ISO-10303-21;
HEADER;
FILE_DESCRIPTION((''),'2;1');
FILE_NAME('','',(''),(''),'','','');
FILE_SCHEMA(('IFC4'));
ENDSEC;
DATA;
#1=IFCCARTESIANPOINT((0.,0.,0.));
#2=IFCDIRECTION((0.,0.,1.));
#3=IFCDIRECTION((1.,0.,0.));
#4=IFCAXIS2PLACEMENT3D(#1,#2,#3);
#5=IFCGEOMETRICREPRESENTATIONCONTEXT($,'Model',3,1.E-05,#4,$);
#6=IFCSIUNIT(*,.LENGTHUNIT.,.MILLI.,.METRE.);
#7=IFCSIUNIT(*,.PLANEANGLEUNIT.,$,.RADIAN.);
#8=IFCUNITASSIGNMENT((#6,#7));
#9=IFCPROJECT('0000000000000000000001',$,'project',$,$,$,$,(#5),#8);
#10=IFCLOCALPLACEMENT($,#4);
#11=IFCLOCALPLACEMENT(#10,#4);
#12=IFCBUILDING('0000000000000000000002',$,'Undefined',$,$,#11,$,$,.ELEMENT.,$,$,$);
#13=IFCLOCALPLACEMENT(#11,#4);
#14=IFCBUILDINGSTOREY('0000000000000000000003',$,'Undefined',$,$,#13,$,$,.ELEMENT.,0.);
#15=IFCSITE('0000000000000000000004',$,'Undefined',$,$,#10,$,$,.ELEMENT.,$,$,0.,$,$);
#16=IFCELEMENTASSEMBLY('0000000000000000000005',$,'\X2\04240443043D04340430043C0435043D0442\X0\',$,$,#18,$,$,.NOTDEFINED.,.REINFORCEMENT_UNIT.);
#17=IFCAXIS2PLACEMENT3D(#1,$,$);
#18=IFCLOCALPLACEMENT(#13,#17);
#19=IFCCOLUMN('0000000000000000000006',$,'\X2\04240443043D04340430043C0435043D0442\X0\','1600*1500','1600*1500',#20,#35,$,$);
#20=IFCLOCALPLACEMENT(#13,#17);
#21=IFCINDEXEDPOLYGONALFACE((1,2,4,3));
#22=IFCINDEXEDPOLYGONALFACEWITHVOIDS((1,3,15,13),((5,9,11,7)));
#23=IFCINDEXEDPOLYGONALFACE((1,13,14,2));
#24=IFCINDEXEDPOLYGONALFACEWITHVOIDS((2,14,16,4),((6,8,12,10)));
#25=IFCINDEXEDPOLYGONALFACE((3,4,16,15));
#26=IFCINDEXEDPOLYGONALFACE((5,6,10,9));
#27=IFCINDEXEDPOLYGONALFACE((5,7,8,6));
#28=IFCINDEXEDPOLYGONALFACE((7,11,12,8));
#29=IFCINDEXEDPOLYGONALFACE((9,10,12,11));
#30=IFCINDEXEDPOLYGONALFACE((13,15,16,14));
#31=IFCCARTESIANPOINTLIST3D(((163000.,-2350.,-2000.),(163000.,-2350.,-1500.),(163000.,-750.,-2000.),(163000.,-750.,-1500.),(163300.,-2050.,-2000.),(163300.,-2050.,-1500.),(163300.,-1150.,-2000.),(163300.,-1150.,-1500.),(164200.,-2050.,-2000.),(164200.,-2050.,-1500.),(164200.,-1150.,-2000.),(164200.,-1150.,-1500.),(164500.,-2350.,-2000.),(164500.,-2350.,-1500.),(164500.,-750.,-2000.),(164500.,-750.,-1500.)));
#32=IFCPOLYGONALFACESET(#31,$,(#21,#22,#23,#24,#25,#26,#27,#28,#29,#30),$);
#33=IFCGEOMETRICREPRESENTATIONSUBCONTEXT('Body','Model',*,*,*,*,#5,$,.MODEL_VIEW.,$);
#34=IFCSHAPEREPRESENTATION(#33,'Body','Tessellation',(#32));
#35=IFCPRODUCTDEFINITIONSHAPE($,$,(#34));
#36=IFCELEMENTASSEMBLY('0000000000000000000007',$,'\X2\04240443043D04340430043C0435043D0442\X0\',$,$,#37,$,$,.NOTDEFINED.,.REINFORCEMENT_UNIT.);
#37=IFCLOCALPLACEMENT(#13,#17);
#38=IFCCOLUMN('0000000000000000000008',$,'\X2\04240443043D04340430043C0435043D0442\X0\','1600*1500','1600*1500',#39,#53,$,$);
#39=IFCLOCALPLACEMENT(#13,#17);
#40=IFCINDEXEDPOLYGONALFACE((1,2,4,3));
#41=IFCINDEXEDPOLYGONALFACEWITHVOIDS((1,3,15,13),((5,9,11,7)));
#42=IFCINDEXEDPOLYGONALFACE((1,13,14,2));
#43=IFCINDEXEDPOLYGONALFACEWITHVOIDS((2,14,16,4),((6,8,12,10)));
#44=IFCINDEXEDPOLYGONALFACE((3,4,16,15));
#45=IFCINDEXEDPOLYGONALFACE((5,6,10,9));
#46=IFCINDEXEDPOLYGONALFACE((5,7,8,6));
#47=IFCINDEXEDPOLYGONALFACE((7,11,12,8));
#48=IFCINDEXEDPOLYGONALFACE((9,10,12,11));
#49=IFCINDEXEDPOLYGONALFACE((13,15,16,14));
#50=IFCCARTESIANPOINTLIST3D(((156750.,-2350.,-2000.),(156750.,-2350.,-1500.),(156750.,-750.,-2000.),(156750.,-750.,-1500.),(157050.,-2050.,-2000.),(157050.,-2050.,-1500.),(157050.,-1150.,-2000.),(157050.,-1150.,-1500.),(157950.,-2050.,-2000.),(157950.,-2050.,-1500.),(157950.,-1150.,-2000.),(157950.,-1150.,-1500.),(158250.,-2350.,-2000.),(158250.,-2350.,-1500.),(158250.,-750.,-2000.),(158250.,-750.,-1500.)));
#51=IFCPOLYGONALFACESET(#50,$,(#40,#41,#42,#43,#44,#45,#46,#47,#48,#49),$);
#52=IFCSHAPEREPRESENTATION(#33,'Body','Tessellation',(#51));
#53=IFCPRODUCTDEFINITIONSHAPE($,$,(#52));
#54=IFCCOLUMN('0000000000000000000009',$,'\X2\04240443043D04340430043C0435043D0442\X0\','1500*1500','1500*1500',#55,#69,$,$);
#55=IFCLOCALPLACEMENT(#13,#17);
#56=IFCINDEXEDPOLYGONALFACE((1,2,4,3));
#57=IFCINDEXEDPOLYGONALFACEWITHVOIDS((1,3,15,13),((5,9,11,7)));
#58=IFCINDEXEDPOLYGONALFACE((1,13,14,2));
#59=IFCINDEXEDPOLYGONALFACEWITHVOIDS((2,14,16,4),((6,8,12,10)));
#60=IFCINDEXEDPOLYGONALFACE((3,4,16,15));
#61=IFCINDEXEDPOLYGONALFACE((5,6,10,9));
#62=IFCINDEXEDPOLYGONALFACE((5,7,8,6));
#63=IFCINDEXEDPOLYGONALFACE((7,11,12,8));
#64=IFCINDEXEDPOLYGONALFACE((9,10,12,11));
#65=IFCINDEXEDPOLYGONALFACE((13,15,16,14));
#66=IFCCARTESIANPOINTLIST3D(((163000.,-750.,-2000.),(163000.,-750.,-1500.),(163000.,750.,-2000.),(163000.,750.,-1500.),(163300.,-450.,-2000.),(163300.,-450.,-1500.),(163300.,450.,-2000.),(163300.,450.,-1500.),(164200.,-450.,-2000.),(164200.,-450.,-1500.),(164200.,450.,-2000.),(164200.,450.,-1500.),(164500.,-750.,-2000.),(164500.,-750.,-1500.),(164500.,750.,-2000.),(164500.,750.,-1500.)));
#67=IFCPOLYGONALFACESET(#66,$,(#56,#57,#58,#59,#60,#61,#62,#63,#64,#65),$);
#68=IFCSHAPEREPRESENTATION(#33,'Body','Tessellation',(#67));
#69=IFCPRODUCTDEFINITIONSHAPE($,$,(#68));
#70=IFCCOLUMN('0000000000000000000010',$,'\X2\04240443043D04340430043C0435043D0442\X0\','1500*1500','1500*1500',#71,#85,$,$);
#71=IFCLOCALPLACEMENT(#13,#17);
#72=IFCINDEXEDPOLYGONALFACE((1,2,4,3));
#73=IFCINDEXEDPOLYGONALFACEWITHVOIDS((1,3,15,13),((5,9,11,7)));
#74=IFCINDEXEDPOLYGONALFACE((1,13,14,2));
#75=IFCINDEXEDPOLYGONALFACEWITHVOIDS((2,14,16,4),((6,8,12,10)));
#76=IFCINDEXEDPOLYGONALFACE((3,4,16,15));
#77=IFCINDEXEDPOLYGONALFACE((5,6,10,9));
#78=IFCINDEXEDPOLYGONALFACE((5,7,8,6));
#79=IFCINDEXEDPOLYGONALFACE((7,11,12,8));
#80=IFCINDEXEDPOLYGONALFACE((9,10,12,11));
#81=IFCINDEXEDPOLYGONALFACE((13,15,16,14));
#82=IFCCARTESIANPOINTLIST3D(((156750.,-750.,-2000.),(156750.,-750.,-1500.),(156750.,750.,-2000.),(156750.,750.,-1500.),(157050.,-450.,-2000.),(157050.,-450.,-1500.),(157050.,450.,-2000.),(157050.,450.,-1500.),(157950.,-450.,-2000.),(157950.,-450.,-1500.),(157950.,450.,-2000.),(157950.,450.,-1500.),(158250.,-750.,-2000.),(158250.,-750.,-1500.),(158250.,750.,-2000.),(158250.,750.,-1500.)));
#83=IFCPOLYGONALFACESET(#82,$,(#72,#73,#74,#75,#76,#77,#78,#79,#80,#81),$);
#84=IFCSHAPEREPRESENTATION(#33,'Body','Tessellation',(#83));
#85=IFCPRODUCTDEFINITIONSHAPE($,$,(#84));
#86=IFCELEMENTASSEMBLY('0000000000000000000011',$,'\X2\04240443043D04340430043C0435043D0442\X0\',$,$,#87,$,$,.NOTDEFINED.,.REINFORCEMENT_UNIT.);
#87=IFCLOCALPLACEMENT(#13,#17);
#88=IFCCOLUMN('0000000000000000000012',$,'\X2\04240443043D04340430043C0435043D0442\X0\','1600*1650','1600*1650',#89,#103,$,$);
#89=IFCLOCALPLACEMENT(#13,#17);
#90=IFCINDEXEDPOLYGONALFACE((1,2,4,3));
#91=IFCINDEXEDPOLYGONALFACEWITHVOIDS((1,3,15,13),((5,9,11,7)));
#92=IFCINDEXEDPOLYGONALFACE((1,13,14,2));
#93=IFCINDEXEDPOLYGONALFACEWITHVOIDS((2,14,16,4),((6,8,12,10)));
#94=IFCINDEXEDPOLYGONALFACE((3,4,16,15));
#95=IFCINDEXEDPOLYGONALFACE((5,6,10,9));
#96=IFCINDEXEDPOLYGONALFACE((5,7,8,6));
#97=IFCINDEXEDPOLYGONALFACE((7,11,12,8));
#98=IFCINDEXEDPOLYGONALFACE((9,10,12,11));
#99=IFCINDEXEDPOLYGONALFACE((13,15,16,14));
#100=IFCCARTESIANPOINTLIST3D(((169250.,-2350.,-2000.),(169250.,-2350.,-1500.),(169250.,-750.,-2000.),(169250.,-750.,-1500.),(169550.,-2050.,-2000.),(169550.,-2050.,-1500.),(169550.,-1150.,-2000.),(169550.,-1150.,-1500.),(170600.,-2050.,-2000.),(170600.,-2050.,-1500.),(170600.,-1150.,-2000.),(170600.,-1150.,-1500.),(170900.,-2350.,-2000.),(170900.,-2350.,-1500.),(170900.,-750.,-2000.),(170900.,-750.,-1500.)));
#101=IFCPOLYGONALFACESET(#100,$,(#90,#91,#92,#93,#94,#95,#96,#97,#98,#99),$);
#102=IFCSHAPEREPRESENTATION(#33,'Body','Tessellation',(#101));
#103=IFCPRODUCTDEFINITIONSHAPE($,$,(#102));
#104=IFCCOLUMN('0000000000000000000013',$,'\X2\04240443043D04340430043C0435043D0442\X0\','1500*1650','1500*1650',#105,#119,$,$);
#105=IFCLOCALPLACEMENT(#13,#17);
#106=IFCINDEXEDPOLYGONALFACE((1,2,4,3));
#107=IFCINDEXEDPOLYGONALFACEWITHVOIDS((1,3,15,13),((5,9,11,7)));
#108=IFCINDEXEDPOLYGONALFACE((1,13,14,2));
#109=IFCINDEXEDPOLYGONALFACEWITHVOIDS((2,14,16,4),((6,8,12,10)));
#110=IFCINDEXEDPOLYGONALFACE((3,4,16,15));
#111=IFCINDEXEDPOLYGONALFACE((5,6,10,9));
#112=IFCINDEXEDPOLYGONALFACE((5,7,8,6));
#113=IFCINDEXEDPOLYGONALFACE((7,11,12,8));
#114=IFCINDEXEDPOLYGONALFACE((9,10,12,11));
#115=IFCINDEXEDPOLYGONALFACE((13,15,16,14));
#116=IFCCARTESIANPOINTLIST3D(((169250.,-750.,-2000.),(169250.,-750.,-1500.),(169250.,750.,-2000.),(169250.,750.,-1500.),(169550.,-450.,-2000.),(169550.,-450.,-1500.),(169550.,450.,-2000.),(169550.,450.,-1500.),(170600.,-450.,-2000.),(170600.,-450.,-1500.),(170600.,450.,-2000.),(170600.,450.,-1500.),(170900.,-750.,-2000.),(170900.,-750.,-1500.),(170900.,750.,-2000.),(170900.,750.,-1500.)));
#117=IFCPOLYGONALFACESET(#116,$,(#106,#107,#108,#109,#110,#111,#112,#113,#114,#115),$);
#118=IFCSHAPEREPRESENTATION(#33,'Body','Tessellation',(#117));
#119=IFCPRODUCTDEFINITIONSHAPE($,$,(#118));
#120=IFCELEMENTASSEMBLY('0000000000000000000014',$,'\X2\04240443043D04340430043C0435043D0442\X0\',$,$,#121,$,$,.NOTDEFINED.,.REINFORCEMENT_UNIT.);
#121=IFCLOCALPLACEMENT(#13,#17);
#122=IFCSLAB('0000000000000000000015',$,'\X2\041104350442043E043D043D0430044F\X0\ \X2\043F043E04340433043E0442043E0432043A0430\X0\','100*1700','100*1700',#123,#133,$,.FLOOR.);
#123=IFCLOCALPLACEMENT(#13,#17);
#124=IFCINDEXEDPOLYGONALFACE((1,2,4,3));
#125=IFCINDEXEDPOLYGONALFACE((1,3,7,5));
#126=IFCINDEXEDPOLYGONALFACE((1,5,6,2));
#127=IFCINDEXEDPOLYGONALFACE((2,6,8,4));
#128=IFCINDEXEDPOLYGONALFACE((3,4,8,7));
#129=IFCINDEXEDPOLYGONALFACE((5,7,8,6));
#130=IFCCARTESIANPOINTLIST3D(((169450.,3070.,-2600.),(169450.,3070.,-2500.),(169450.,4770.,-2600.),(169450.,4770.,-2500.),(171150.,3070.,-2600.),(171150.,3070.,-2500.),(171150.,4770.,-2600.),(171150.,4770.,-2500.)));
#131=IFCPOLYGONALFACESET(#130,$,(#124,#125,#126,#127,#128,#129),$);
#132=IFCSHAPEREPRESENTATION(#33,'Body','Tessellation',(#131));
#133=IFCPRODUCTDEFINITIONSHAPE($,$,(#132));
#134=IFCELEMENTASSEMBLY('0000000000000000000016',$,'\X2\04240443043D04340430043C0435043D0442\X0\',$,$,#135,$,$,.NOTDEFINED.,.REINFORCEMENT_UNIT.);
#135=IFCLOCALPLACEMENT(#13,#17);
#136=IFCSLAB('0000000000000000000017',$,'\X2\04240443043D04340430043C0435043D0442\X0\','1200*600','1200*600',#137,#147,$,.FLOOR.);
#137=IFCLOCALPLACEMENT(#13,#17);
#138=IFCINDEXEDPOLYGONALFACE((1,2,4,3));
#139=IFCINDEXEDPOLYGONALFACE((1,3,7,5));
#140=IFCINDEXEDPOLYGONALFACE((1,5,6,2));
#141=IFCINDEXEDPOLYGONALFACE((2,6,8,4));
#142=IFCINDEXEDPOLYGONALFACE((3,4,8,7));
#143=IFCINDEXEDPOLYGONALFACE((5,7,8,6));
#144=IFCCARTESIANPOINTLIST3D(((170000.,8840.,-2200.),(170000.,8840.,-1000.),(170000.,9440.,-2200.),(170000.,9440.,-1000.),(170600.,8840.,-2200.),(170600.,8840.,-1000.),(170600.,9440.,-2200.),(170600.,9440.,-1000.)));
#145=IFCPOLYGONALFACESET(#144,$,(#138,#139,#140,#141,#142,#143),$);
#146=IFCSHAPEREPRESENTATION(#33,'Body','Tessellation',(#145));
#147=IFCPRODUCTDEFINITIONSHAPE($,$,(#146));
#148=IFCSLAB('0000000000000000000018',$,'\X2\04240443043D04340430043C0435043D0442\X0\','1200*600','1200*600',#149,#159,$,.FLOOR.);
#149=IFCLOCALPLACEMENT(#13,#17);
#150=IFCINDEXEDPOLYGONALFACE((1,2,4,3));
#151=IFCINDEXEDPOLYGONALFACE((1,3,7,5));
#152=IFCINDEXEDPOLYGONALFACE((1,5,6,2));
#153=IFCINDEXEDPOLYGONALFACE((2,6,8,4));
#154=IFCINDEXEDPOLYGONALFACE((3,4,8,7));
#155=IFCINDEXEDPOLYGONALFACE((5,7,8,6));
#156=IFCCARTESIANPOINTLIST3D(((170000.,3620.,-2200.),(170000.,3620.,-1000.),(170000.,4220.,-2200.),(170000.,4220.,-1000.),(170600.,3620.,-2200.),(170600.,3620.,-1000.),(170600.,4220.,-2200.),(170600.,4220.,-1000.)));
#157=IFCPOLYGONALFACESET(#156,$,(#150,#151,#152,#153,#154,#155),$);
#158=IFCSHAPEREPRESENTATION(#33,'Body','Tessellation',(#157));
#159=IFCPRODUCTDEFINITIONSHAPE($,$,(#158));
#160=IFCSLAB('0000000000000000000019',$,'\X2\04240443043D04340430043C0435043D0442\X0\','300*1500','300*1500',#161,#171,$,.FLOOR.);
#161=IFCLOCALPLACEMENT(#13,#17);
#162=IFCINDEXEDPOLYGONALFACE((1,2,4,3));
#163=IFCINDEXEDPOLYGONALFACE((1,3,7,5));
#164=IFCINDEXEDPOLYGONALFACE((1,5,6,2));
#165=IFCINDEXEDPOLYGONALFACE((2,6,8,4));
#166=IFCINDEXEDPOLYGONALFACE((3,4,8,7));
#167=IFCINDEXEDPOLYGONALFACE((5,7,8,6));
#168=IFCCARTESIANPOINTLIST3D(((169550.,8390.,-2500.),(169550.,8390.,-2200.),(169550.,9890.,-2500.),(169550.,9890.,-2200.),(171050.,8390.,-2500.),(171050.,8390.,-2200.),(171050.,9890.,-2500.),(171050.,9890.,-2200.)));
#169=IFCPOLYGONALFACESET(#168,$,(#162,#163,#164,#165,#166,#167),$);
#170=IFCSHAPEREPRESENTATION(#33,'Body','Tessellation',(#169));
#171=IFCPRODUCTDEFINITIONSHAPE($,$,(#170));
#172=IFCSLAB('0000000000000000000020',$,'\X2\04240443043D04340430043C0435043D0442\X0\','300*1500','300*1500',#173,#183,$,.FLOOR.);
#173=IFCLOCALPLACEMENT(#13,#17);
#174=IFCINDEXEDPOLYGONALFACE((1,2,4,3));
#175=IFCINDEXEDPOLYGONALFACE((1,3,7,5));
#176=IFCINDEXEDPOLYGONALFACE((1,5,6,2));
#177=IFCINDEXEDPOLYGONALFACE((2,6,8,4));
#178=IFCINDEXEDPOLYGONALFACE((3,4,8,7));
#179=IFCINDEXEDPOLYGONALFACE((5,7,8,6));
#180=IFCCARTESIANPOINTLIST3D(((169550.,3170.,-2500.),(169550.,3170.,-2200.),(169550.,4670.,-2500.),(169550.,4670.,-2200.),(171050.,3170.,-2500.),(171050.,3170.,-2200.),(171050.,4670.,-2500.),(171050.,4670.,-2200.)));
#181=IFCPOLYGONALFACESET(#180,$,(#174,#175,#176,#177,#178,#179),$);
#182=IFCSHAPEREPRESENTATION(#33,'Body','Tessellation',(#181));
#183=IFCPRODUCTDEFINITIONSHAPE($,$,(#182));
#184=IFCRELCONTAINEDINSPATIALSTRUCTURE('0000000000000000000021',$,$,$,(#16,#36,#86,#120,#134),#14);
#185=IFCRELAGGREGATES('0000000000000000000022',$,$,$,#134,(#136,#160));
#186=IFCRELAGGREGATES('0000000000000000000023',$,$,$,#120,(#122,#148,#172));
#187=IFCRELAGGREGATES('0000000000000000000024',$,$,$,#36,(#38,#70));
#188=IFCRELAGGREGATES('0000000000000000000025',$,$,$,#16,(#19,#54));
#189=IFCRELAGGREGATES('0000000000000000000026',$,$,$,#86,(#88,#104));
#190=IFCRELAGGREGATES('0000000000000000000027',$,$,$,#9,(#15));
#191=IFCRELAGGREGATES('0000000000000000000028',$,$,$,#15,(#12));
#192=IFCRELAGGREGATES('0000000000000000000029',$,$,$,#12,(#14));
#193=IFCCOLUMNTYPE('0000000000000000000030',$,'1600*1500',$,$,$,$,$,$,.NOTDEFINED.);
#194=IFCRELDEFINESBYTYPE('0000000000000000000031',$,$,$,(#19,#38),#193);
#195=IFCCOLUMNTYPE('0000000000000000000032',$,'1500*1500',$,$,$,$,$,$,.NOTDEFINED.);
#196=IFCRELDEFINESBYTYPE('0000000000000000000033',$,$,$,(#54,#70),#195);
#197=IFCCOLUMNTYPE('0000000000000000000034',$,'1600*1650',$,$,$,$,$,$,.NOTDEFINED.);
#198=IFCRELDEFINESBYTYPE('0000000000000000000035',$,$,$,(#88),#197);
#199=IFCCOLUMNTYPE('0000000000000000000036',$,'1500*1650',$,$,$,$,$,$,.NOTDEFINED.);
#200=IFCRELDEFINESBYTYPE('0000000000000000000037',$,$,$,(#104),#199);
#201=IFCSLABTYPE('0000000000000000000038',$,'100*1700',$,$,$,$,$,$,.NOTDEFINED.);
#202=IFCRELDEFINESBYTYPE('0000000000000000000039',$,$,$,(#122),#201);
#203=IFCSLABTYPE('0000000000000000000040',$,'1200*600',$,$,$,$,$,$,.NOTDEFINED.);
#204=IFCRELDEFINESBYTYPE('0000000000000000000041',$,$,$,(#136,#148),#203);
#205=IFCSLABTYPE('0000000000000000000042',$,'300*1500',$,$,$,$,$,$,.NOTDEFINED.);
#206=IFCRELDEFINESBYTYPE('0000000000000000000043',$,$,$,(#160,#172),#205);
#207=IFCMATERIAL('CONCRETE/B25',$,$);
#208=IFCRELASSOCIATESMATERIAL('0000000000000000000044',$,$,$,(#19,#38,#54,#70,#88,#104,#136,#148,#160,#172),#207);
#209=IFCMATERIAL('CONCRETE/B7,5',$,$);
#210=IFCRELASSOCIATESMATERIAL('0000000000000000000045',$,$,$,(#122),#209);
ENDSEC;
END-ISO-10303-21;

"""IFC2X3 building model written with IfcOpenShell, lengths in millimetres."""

from ifc_helpers import new_model, si_unit, frame, origin_with_axes, origin_2d_with_axis, place, context, subcontext, project, spatial, polyline, rectangle, outline, extrude, boolean, material, type_object, element, aggregate, save


model = new_model("IFC2X3")

# Units and contexts
model_context = context("Model", 3, precision=1e-05, world=origin_with_axes())
body_context = subcontext(model_context, "Body", "Model", "MODEL_VIEW")
ifc_project = project(units=[si_unit("LENGTHUNIT", "METRE", prefix="MILLI"), si_unit("PLANEANGLEUNIT", "RADIAN")], contexts=[model_context])

# Site, building, storey
site_placement = place(None, origin_with_axes())
site = spatial("IfcSite", under=ifc_project, at=site_placement, Name="Undefined", CompositionType="ELEMENT", RefElevation=0.0)
building_placement = place(site_placement, origin_with_axes())
building = spatial("IfcBuilding", under=site, at=building_placement, Name="Undefined", CompositionType="ELEMENT")
storey_placement = place(building_placement, origin_with_axes())
storey = spatial("IfcBuildingStorey", under=building, at=storey_placement, Name="Undefined", CompositionType="ELEMENT", Elevation=0.0)

# Element assemblies, columns
assembly_1_placement = place(storey_placement, origin_with_axes())
assembly_1 = element("IfcElementAssembly", 1, at=assembly_1_placement, inside=storey, Name="Фундамент", AssemblyPlace="NOTDEFINED", PredefinedType="REINFORCEMENT_UNIT")
ifc_material_1 = material(Name="CONCRETE/B25")
column_type_1 = type_object("IfcColumnType", Name="1600*1500", PredefinedType="NOTDEFINED")
column_1_placement = place(assembly_1_placement, frame((163750.0, -1550.0, -2000.0), z_axis=(0.0, 0.0, 1.0), x_axis=(0.0, -1.0, 0.0)))
column_1 = element("IfcColumn", 2, at=column_1_placement, type_object=column_type_1, material=ifc_material_1, Name="Фундамент", Description="1600*1500", ObjectType="1600*1500", context=body_context, shape_type="CSG", body=[
    boolean("DIFFERENCE", extrude(rectangle(XDim=1500.0, YDim=1600.0, at=origin_2d_with_axis()), frame((0.0, 0.0, 500.0), z_axis=(0.0, 0.0, -1.0), x_axis=(0.0, 1.0, 0.0)), (0.0, 0.0, 1.0), 500.0), extrude(outline(polyline([(0.0, 0.0), (900.0, 0.0), (900.0, 900.0), (0.0, 900.0), (0.0, 0.0)])), frame((-400.0, -450.0, -100.0), z_axis=(0.0, 0.0, 1.0), x_axis=(1.0, 0.0, 0.0)), (0.0, 0.0, 1.0), 700.0)),
])
assembly_2_placement = place(storey_placement, origin_with_axes())
assembly_2 = element("IfcElementAssembly", 3, at=assembly_2_placement, inside=storey, Name="Фундамент", AssemblyPlace="NOTDEFINED", PredefinedType="REINFORCEMENT_UNIT")
column_2_placement = place(assembly_2_placement, frame((157500.0, -1550.0, -2000.0), z_axis=(0.0, 0.0, 1.0), x_axis=(0.0, -1.0, 0.0)))
column_2 = element("IfcColumn", 4, at=column_2_placement, type_object=column_type_1, material=ifc_material_1, Name="Фундамент", Description="1600*1500", ObjectType="1600*1500", context=body_context, shape_type="CSG", body=[
    boolean("DIFFERENCE", extrude(rectangle(XDim=1500.0, YDim=1600.0, at=origin_2d_with_axis()), frame((0.0, 0.0, 500.0), z_axis=(0.0, 0.0, -1.0), x_axis=(0.0, 1.0, 0.0)), (0.0, 0.0, 1.0), 500.0), extrude(outline(polyline([(0.0, 0.0), (900.0, 0.0), (900.0, 900.0), (0.0, 900.0), (0.0, 0.0)])), frame((-400.0, -450.0, -100.0), z_axis=(0.0, 0.0, 1.0), x_axis=(1.0, 0.0, 0.0)), (0.0, 0.0, 1.0), 700.0)),
])

# Columns
column_type_2 = type_object("IfcColumnType", Name="1500*1500", PredefinedType="NOTDEFINED")
column_3_placement = place(assembly_1_placement, frame((163750.0, 0.0, -2000.0), z_axis=(0.0, 0.0, 1.0), x_axis=(0.0, -1.0, 0.0)))
column_3 = element("IfcColumn", 5, at=column_3_placement, type_object=column_type_2, material=ifc_material_1, Name="Фундамент", Description="1500*1500", ObjectType="1500*1500", context=body_context, shape_type="CSG", body=[
    boolean("DIFFERENCE", extrude(rectangle(XDim=1500.0, YDim=1500.0, at=origin_2d_with_axis()), frame((0.0, 0.0, 500.0), z_axis=(0.0, 0.0, -1.0), x_axis=(0.0, 1.0, 0.0)), (0.0, 0.0, 1.0), 500.0), extrude(outline(polyline([(0.0, 0.0), (900.0, 0.0), (900.0, 900.0), (0.0, 900.0), (0.0, 0.0)])), frame((-450.0, -450.0, -100.0), z_axis=(0.0, 0.0, 1.0), x_axis=(1.0, 0.0, 0.0)), (0.0, 0.0, 1.0), 700.0)),
])
column_4_placement = place(assembly_2_placement, frame((157500.0, 0.0, -2000.0), z_axis=(0.0, 0.0, 1.0), x_axis=(0.0, -1.0, 0.0)))
column_4 = element("IfcColumn", 6, at=column_4_placement, type_object=column_type_2, material=ifc_material_1, Name="Фундамент", Description="1500*1500", ObjectType="1500*1500", context=body_context, shape_type="CSG", body=[
    boolean("DIFFERENCE", extrude(rectangle(XDim=1500.0, YDim=1500.0, at=origin_2d_with_axis()), frame((0.0, 0.0, 500.0), z_axis=(0.0, 0.0, -1.0), x_axis=(0.0, 1.0, 0.0)), (0.0, 0.0, 1.0), 500.0), extrude(outline(polyline([(0.0, 0.0), (900.0, 0.0), (900.0, 900.0), (0.0, 900.0), (0.0, 0.0)])), frame((-450.0, -450.0, -100.0), z_axis=(0.0, 0.0, 1.0), x_axis=(1.0, 0.0, 0.0)), (0.0, 0.0, 1.0), 700.0)),
])

# Element assembly, columns
assembly_3_placement = place(storey_placement, origin_with_axes())
assembly_3 = element("IfcElementAssembly", 7, at=assembly_3_placement, inside=storey, Name="Фундамент", AssemblyPlace="NOTDEFINED", PredefinedType="REINFORCEMENT_UNIT")
column_type_3 = type_object("IfcColumnType", Name="1600*1650", PredefinedType="NOTDEFINED")
column_5_placement = place(assembly_3_placement, frame((170075.0, -1550.0, -2000.0), z_axis=(0.0, 0.0, 1.0), x_axis=(0.0, -1.0, 0.0)))
column_5 = element("IfcColumn", 8, at=column_5_placement, type_object=column_type_3, material=ifc_material_1, Name="Фундамент", Description="1600*1650", ObjectType="1600*1650", context=body_context, shape_type="CSG", body=[
    boolean("DIFFERENCE", extrude(rectangle(XDim=1650.0, YDim=1600.0, at=origin_2d_with_axis()), frame((0.0, 0.0, 500.0), z_axis=(0.0, 0.0, -1.0), x_axis=(0.0, 1.0, 0.0)), (0.0, 0.0, 1.0), 500.0), extrude(outline(polyline([(0.0, 0.0), (900.0, 0.0), (900.0, 1050.0), (0.0, 1050.0), (0.0, 0.0)])), frame((-400.0, -525.0, -100.0), z_axis=(0.0, 0.0, 1.0), x_axis=(1.0, 0.0, 0.0)), (0.0, 0.0, 1.0), 700.0)),
])
column_type_4 = type_object("IfcColumnType", Name="1500*1650", PredefinedType="NOTDEFINED")
column_6_placement = place(assembly_3_placement, frame((170075.0, 0.0, -2000.0), z_axis=(0.0, 0.0, 1.0), x_axis=(0.0, -1.0, 0.0)))
column_6 = element("IfcColumn", 9, at=column_6_placement, type_object=column_type_4, material=ifc_material_1, Name="Фундамент", Description="1500*1650", ObjectType="1500*1650", context=body_context, shape_type="CSG", body=[
    boolean("DIFFERENCE", extrude(rectangle(XDim=1650.0, YDim=1500.0, at=origin_2d_with_axis()), frame((0.0, 0.0, 500.0), z_axis=(0.0, 0.0, -1.0), x_axis=(0.0, 1.0, 0.0)), (0.0, 0.0, 1.0), 500.0), extrude(outline(polyline([(0.0, 0.0), (900.0, 0.0), (900.0, 1050.0), (0.0, 1050.0), (0.0, 0.0)])), frame((-450.0, -525.0, -100.0), z_axis=(0.0, 0.0, 1.0), x_axis=(1.0, 0.0, 0.0)), (0.0, 0.0, 1.0), 700.0)),
])

# Element assemblies, slabs
assembly_4_placement = place(storey_placement, origin_with_axes())
assembly_4 = element("IfcElementAssembly", 10, at=assembly_4_placement, inside=storey, Name="Фундамент", AssemblyPlace="NOTDEFINED", PredefinedType="REINFORCEMENT_UNIT")
ifc_material_2 = material(Name="CONCRETE/B7,5")
slab_type_1 = type_object("IfcSlabType", Name="100*1700", PredefinedType="NOTDEFINED")
slab_1_placement = place(assembly_4_placement, frame((169450.0, 4770.0, -2550.0), z_axis=(0.0, 0.0, 1.0), x_axis=(0.0, -1.0, 0.0)))
slab_1 = element("IfcSlab", 11, at=slab_1_placement, type_object=slab_type_1, material=ifc_material_2, Name="Бетонная подготовка", Description="100*1700", ObjectType="100*1700", PredefinedType="FLOOR", context=body_context, shape_type="SweptSolid", body=[
    extrude(outline(polyline([(0.0, 0.0), (1700.0, 0.0), (1700.0, 1700.0), (0.0, 1700.0), (0.0, 0.0)])), frame((0.0, 0.0, -50.0), z_axis=(0.0, 0.0, 1.0), x_axis=(1.0, 0.0, 0.0)), (0.0, 0.0, 1.0), 100.0),
])
assembly_5_placement = place(storey_placement, origin_with_axes())
assembly_5 = element("IfcElementAssembly", 12, at=assembly_5_placement, inside=storey, Name="Фундамент", AssemblyPlace="NOTDEFINED", PredefinedType="REINFORCEMENT_UNIT")
slab_type_2 = type_object("IfcSlabType", Name="1200*600", PredefinedType="NOTDEFINED")
slab_2_placement = place(assembly_5_placement, frame((170000.0, 9440.0, -1600.0), z_axis=(0.0, 0.0, 1.0), x_axis=(0.0, -1.0, 0.0)))
slab_2 = element("IfcSlab", 13, at=slab_2_placement, type_object=slab_type_2, material=ifc_material_1, Name="Фундамент", Description="1200*600", ObjectType="1200*600", PredefinedType="FLOOR", context=body_context, shape_type="SweptSolid", body=[
    extrude(outline(polyline([(0.0, 0.0), (600.0, 0.0), (600.0, 600.0), (0.0, 600.0), (0.0, 0.0)])), frame((0.0, 0.0, -600.0), z_axis=(0.0, 0.0, 1.0), x_axis=(1.0, 0.0, 0.0)), (0.0, 0.0, 1.0), 1200.0),
])

# Slabs
slab_3_placement = place(assembly_4_placement, frame((170000.0, 4220.0, -1600.0), z_axis=(0.0, 0.0, 1.0), x_axis=(0.0, -1.0, 0.0)))
slab_3 = element("IfcSlab", 14, at=slab_3_placement, type_object=slab_type_2, material=ifc_material_1, Name="Фундамент", Description="1200*600", ObjectType="1200*600", PredefinedType="FLOOR", context=body_context, shape_type="SweptSolid", body=[
    extrude(outline(polyline([(0.0, 0.0), (600.0, 0.0), (600.0, 600.0), (0.0, 600.0), (0.0, 0.0)])), frame((0.0, 0.0, -600.0), z_axis=(0.0, 0.0, 1.0), x_axis=(1.0, 0.0, 0.0)), (0.0, 0.0, 1.0), 1200.0),
])
slab_type_3 = type_object("IfcSlabType", Name="300*1500", PredefinedType="NOTDEFINED")
slab_4_placement = place(assembly_5_placement, frame((169550.0, 9890.0, -2350.0), z_axis=(0.0, 0.0, 1.0), x_axis=(0.0, -1.0, 0.0)))
slab_4 = element("IfcSlab", 15, at=slab_4_placement, type_object=slab_type_3, material=ifc_material_1, Name="Фундамент", Description="300*1500", ObjectType="300*1500", PredefinedType="FLOOR", context=body_context, shape_type="SweptSolid", body=[
    extrude(outline(polyline([(0.0, 0.0), (1500.0, 0.0), (1500.0, 1500.0), (0.0, 1500.0), (0.0, 0.0)])), frame((0.0, 0.0, -150.0), z_axis=(0.0, 0.0, 1.0), x_axis=(1.0, 0.0, 0.0)), (0.0, 0.0, 1.0), 300.0),
])
aggregate(assembly_5, [slab_2, slab_4])
slab_5_placement = place(assembly_4_placement, frame((169550.0, 4670.0, -2350.0), z_axis=(0.0, 0.0, 1.0), x_axis=(0.0, -1.0, 0.0)))
slab_5 = element("IfcSlab", 16, at=slab_5_placement, type_object=slab_type_3, material=ifc_material_1, Name="Фундамент", Description="300*1500", ObjectType="300*1500", PredefinedType="FLOOR", context=body_context, shape_type="SweptSolid", body=[
    extrude(outline(polyline([(0.0, 0.0), (1500.0, 0.0), (1500.0, 1500.0), (0.0, 1500.0), (0.0, 0.0)])), frame((0.0, 0.0, -150.0), z_axis=(0.0, 0.0, 1.0), x_axis=(1.0, 0.0, 0.0)), (0.0, 0.0, 1.0), 300.0),
])
aggregate(assembly_4, [slab_1, slab_3, slab_5])
aggregate(assembly_2, [column_2, column_4])
aggregate(assembly_1, [column_1, column_3])
aggregate(assembly_3, [column_5, column_6])

save(model, "model.ifc")
